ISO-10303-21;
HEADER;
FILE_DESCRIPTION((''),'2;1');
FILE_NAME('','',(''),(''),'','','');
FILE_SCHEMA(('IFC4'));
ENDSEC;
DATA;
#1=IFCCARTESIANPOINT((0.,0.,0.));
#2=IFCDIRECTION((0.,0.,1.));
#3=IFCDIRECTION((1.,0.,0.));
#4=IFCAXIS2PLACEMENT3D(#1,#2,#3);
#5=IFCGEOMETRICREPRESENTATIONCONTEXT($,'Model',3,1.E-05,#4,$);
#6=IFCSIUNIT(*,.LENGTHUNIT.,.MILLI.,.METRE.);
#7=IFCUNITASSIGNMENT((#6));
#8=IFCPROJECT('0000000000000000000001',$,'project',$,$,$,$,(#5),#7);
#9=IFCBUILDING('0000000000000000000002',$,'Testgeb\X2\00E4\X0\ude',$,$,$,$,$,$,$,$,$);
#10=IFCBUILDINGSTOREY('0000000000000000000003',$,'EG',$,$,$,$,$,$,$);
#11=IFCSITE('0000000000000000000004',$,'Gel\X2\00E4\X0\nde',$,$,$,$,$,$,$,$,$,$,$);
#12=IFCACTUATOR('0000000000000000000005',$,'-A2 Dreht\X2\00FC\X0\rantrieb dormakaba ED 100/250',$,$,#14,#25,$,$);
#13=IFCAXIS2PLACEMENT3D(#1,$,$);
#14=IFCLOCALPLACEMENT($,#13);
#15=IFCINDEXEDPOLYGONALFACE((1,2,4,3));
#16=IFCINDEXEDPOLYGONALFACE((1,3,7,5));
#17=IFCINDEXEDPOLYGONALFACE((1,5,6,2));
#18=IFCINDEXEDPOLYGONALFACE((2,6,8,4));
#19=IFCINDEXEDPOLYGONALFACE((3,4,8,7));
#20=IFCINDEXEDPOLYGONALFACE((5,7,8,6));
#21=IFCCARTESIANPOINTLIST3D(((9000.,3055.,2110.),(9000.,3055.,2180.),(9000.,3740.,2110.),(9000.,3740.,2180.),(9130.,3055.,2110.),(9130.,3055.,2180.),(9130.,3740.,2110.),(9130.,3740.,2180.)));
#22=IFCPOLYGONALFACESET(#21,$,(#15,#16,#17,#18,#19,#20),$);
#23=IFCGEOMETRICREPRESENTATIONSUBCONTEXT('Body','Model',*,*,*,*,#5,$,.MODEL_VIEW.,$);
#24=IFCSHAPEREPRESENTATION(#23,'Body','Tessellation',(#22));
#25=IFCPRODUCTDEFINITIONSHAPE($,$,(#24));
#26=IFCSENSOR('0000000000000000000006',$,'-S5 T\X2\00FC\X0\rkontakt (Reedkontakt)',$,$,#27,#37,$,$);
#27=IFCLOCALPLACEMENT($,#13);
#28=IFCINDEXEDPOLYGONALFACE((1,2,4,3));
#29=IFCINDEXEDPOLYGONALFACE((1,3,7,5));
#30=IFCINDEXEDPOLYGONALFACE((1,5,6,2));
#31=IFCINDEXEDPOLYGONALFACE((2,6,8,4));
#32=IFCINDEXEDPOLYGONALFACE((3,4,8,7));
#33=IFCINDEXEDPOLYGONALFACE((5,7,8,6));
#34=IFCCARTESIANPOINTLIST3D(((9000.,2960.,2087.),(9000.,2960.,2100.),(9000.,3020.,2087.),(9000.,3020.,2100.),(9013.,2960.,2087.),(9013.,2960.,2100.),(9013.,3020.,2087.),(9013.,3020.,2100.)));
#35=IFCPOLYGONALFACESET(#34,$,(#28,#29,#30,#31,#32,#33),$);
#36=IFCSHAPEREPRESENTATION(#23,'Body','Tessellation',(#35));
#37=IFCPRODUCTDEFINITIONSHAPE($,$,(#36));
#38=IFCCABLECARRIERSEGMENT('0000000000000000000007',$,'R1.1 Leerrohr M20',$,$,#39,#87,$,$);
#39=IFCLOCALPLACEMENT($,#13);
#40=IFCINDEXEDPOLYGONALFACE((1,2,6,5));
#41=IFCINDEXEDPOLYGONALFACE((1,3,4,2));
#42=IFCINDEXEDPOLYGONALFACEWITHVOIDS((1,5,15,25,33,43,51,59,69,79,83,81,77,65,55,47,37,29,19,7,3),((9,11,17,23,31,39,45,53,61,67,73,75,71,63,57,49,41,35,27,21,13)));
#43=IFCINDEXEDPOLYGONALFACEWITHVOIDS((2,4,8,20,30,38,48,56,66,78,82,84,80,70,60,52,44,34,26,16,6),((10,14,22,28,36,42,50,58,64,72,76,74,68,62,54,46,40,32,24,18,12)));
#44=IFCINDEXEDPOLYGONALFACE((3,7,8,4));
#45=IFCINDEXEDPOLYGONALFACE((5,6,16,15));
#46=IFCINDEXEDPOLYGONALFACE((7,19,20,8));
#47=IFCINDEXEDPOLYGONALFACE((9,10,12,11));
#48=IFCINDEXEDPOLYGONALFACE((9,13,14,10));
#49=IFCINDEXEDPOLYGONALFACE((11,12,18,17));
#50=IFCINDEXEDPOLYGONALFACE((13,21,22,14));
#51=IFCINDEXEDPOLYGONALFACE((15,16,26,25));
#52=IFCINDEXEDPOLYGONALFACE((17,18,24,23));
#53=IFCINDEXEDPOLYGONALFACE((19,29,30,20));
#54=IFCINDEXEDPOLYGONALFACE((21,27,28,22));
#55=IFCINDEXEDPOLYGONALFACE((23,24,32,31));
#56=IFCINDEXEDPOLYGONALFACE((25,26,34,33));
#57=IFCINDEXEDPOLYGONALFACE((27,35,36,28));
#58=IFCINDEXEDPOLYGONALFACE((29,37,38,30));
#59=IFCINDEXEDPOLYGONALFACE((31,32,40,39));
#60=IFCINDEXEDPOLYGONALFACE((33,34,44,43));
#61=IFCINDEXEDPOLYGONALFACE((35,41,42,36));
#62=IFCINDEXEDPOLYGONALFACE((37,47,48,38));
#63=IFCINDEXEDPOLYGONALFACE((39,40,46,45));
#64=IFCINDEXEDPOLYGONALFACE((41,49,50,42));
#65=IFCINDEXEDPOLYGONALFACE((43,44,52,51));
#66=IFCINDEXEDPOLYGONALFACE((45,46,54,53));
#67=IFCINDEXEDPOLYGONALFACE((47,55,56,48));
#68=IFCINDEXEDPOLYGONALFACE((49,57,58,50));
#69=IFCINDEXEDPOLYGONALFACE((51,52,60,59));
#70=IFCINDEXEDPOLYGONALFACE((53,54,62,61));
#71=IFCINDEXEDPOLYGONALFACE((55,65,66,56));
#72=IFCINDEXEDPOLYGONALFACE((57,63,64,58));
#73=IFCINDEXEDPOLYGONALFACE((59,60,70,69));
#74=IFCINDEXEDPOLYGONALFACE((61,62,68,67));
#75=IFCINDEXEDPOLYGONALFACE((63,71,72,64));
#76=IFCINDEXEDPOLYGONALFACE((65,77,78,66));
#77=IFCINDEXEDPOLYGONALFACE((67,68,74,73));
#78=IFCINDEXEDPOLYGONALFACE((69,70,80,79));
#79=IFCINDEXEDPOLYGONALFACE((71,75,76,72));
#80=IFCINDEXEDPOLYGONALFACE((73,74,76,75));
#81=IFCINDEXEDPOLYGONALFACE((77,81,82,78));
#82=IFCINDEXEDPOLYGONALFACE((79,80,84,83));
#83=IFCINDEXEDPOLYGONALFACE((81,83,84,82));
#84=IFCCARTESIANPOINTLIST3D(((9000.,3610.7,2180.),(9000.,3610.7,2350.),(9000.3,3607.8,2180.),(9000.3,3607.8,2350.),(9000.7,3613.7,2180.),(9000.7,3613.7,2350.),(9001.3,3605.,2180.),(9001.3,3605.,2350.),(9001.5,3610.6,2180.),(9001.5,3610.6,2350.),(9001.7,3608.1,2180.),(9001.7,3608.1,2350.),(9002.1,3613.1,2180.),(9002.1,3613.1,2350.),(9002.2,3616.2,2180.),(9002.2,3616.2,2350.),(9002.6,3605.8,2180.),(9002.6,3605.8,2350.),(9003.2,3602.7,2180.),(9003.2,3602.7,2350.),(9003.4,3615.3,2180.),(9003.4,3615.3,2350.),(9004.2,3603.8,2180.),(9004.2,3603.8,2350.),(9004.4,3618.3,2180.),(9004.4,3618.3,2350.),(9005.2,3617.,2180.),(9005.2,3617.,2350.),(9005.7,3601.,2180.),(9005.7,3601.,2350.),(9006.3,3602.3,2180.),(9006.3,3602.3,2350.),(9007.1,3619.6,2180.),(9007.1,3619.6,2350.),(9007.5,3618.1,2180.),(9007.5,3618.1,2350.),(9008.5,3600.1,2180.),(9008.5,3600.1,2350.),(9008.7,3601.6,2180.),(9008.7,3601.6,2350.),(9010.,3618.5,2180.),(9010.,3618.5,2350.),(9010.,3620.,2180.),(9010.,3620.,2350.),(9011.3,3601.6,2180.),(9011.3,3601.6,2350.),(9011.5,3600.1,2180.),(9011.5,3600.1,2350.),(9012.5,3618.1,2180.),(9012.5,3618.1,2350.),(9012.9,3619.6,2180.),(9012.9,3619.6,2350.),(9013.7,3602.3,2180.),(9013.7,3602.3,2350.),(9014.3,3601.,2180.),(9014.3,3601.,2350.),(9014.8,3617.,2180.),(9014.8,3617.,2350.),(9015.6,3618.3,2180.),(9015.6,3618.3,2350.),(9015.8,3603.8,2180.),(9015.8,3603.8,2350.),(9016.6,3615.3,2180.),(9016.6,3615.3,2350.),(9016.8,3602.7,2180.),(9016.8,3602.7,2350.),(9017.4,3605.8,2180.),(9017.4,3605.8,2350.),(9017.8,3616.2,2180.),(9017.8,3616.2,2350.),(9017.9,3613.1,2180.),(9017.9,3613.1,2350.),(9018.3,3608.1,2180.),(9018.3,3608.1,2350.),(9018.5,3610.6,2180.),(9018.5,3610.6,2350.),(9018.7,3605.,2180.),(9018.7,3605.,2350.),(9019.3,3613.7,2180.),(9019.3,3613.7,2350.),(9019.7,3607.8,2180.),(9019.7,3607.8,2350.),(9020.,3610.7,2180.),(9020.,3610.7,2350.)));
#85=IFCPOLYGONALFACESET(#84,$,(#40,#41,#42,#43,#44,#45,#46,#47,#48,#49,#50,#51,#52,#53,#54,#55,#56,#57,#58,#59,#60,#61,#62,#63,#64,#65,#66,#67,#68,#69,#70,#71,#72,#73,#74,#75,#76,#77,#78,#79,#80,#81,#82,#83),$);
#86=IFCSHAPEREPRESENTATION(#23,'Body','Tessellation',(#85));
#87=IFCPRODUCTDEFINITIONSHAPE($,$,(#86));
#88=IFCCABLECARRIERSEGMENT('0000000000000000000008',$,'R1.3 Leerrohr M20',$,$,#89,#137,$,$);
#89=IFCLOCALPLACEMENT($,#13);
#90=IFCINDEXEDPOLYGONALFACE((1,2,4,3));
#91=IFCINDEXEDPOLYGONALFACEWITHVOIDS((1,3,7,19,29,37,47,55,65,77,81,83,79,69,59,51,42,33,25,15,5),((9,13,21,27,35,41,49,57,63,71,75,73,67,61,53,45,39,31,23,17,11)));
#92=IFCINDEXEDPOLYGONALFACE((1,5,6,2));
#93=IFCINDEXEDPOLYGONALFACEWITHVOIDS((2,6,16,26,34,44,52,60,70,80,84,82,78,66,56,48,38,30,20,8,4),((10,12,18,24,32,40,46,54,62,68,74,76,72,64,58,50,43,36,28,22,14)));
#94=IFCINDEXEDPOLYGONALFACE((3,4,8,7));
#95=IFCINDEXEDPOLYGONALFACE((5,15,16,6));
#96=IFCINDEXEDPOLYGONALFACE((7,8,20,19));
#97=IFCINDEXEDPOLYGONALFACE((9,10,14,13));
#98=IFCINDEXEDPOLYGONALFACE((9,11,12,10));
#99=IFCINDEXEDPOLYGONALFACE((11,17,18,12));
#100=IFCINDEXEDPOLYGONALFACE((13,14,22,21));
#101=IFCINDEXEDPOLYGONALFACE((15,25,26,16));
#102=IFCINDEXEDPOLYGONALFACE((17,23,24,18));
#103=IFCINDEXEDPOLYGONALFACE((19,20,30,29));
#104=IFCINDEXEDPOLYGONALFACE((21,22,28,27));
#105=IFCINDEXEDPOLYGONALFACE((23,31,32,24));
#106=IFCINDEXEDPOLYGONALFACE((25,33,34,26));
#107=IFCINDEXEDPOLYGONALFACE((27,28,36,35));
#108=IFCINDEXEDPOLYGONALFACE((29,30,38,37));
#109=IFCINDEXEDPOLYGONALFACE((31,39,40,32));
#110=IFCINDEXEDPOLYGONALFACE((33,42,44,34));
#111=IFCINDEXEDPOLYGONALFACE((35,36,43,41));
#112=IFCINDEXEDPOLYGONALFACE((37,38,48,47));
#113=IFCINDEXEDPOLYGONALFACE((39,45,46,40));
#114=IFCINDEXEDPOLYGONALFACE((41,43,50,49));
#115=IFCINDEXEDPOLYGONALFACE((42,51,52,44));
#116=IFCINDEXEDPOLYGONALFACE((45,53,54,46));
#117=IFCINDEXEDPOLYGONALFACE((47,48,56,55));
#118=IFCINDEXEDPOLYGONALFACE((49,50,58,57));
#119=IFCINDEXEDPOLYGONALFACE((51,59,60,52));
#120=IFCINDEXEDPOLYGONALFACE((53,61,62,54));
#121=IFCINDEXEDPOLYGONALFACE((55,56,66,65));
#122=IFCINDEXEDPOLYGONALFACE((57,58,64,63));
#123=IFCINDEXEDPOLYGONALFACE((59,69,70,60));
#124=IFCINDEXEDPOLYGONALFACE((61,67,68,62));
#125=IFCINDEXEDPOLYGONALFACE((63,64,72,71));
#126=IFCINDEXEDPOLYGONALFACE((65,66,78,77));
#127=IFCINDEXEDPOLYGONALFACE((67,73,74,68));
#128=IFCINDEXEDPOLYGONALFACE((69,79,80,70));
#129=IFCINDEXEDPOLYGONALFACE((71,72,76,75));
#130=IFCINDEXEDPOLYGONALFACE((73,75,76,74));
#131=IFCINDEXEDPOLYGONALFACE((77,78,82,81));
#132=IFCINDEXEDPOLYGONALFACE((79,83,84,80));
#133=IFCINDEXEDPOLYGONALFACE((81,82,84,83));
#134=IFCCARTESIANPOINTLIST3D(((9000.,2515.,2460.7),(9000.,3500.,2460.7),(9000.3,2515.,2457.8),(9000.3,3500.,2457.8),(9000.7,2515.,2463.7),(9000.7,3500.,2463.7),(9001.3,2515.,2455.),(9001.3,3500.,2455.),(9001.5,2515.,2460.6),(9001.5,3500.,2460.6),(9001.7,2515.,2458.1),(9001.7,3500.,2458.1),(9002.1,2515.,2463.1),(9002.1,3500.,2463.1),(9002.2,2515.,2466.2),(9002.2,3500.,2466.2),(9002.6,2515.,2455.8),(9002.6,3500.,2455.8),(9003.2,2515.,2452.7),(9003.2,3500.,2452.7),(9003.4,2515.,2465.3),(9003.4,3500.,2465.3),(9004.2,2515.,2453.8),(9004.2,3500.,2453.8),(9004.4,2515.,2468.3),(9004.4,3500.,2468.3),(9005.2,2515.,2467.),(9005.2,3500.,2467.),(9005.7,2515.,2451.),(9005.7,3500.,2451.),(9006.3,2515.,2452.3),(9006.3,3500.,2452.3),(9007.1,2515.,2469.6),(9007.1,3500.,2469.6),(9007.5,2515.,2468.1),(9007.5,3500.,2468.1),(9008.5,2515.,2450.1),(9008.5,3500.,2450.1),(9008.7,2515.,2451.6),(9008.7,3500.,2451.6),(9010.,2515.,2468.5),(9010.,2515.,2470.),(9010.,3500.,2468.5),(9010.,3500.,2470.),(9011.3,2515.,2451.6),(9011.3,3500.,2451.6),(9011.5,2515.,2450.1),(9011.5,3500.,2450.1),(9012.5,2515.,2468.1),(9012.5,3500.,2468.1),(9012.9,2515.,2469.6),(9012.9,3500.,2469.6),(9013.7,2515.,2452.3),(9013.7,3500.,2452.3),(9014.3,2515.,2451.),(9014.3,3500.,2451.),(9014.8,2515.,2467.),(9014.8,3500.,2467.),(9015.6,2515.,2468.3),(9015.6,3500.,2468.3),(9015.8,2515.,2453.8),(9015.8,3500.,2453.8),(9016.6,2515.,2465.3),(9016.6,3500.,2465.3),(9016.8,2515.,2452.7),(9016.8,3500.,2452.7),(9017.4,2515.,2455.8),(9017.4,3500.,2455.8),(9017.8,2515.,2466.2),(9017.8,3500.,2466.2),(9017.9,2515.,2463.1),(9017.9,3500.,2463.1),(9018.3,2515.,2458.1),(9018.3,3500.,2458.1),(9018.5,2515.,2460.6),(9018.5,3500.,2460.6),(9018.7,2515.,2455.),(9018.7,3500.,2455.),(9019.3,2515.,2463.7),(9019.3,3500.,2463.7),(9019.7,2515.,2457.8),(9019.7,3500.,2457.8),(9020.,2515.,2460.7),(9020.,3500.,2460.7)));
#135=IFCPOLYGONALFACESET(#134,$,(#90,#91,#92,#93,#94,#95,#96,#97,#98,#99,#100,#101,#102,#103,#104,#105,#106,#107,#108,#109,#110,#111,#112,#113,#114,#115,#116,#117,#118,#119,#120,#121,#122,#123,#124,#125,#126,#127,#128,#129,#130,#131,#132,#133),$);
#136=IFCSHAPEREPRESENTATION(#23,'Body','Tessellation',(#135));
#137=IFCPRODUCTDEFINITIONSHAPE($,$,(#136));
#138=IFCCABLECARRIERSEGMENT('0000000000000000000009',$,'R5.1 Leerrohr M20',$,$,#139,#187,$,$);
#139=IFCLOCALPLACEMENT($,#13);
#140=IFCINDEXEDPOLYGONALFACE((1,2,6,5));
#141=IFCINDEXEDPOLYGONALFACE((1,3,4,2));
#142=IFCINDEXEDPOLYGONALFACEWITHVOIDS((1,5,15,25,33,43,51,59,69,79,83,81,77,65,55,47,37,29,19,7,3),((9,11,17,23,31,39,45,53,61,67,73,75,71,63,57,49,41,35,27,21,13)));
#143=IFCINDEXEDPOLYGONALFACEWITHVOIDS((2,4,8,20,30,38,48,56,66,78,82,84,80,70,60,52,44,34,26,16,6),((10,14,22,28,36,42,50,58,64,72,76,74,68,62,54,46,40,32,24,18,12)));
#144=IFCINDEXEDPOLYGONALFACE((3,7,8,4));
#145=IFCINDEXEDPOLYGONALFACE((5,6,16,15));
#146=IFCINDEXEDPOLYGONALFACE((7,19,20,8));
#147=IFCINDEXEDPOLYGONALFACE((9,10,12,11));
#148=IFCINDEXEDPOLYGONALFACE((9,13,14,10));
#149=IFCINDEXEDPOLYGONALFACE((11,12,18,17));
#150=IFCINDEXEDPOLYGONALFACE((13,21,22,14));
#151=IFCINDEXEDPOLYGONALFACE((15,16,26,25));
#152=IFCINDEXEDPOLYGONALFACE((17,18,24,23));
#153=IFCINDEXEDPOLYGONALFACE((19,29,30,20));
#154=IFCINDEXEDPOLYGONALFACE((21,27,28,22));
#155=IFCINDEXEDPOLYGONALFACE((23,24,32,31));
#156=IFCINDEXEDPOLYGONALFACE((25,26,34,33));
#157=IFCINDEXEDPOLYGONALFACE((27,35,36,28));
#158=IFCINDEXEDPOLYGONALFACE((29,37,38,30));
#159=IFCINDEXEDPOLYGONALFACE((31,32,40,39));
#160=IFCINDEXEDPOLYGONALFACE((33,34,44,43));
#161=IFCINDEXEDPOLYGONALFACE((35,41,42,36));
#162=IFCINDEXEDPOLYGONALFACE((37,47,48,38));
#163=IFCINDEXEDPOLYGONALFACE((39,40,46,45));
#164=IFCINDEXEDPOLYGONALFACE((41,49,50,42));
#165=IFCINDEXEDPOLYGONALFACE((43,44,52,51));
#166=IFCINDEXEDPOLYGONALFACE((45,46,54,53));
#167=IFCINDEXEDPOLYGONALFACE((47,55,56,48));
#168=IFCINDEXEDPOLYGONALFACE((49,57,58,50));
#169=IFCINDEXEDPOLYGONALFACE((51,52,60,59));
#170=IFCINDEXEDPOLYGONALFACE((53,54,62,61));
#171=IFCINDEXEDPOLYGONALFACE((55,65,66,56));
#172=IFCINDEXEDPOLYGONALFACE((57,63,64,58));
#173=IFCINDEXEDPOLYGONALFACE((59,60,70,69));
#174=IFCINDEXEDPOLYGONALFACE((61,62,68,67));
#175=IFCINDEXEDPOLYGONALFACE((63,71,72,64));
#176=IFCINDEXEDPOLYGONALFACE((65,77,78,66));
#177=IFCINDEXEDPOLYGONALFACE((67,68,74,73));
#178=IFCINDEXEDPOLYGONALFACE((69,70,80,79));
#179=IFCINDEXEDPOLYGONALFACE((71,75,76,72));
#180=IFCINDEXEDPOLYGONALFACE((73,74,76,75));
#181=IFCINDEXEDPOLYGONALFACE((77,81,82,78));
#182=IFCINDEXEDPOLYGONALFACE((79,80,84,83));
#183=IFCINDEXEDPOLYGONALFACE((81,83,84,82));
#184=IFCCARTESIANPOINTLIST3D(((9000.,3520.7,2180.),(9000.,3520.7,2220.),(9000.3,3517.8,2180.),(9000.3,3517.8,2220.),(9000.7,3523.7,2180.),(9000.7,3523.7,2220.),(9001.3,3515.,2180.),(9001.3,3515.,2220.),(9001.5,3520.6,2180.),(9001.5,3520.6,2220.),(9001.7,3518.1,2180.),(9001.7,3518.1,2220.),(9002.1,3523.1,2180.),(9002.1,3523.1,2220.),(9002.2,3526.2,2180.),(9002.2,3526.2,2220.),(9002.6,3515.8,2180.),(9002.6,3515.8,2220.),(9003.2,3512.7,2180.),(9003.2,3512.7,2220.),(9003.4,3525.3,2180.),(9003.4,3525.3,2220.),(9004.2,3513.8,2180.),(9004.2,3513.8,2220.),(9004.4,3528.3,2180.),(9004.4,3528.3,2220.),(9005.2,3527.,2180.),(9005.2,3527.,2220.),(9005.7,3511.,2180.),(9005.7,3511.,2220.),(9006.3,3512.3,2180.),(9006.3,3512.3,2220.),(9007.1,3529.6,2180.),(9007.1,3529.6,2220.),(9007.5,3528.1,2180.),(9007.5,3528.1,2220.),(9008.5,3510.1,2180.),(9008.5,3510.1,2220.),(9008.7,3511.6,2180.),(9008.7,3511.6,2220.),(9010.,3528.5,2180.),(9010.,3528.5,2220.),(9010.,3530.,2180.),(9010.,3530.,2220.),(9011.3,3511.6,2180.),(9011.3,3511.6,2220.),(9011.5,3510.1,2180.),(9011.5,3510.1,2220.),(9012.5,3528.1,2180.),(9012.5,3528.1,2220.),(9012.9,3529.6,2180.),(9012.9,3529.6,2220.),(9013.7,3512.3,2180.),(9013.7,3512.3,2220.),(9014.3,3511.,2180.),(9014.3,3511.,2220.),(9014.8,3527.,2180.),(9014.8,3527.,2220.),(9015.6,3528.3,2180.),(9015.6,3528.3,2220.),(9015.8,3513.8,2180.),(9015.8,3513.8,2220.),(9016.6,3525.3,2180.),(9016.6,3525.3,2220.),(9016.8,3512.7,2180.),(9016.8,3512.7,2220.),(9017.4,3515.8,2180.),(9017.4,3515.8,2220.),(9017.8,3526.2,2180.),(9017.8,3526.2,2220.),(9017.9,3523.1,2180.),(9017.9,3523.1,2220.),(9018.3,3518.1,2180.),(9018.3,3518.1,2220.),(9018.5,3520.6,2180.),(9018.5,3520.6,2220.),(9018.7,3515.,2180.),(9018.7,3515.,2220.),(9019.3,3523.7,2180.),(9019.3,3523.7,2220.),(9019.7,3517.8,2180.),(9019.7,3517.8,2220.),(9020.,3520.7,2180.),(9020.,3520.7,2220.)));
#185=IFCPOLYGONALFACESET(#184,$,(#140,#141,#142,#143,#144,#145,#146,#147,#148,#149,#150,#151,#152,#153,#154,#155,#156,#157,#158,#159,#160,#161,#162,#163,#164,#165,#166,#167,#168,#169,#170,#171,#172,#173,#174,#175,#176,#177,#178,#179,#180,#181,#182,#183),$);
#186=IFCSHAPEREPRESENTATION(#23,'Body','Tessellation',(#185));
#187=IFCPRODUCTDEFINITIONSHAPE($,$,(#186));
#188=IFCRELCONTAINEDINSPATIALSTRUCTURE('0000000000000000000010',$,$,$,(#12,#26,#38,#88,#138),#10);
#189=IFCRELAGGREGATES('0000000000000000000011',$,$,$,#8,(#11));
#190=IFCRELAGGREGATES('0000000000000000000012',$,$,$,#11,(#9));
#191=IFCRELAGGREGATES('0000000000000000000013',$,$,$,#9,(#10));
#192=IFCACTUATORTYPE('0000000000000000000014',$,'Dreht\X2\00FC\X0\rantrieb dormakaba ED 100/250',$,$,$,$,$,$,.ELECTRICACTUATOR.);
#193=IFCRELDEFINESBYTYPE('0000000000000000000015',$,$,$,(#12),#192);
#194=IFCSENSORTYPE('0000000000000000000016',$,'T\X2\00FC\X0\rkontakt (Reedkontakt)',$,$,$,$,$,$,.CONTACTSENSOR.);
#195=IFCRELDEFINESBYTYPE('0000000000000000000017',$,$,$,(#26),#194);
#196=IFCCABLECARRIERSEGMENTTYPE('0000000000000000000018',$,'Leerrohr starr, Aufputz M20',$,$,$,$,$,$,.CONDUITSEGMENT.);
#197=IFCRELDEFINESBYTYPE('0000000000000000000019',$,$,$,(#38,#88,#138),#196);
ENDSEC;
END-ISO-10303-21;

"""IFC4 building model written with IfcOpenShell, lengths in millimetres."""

from ifc_helpers import new_model, si_unit, frame, frame_2d, origin_with_axes, place, context, subcontext, project, spatial, rectangle, hollow_circle, extrude, type_object, element, save


model = new_model("IFC4")

# Units and contexts
model_context = context("Model", 3, precision=1e-05, world=origin_with_axes())
body_context = subcontext(model_context, "Body", "Model", "MODEL_VIEW")
ifc_project = project(units=[si_unit("LENGTHUNIT", "METRE", prefix="MILLI")], contexts=[model_context])

# Site, building, storey
site = spatial("IfcSite", under=ifc_project, Name="Gelände")
building = spatial("IfcBuilding", under=site, Name="Testgebäude")
storey = spatial("IfcBuildingStorey", under=building, Name="EG")

# Actuator
actuator_type = type_object("IfcActuatorType", Name="Drehtürantrieb dormakaba ED 100/250", PredefinedType="ELECTRICACTUATOR")
actuator_placement = place(None, frame((9130.0, 3055.0, 2110.0), z_axis=(0.0, 0.0, 1.0), x_axis=(0.0, 1.0, 0.0)))
element("IfcActuator", 1, at=actuator_placement, inside=storey, type_object=actuator_type, Name="-A2 Drehtürantrieb dormakaba ED 100/250", context=body_context, shape_type="SweptSolid", body=[
    extrude(rectangle(XDim=685.0, YDim=130.0, at=frame_2d((342.5, 65.0))), None, (0.0, 0.0, 1.0), 70.0),
])

# Sensor
sensor_type = type_object("IfcSensorType", Name="Türkontakt (Reedkontakt)", PredefinedType="CONTACTSENSOR")
sensor_placement = place(None, frame((9013.0, 2960.0, 2087.0), z_axis=(0.0, 0.0, 1.0), x_axis=(0.0, 1.0, 0.0)))
element("IfcSensor", 2, at=sensor_placement, inside=storey, type_object=sensor_type, Name="-S5 Türkontakt (Reedkontakt)", context=body_context, shape_type="SweptSolid", body=[
    extrude(rectangle(XDim=60.0, YDim=13.0, at=frame_2d((30.0, 6.5))), None, (0.0, 0.0, 1.0), 13.0),
])

# Cable carrier segments
cable_carrier_segment_type_1 = type_object("IfcCableCarrierSegmentType", Name="Leerrohr starr, Aufputz M20", PredefinedType="CONDUITSEGMENT")
cable_carrier_segment_1_placement = place(None, frame((9010.0, 3610.0, 2180.0), z_axis=(0.0, 0.0, 1.0), x_axis=(0.0, 1.0, 0.0)))
element("IfcCableCarrierSegment", 3, at=cable_carrier_segment_1_placement, inside=storey, type_object=cable_carrier_segment_type_1, Name="R1.1 Leerrohr M20", context=body_context, shape_type="SweptSolid", body=[
    extrude(hollow_circle(Radius=10.0, WallThickness=1.5), None, (0.0, 0.0, 1.0), 170.0),
])
cable_carrier_segment_2_placement = place(None, frame((9010.0, 3500.0, 2460.0), z_axis=(0.0, -1.0, 0.0), x_axis=(0.0, 0.0, 1.0)))
element("IfcCableCarrierSegment", 4, at=cable_carrier_segment_2_placement, inside=storey, type_object=cable_carrier_segment_type_1, Name="R1.3 Leerrohr M20", context=body_context, shape_type="SweptSolid", body=[
    extrude(hollow_circle(Radius=10.0, WallThickness=1.5), None, (0.0, 0.0, 1.0), 985.0),
])
cable_carrier_segment_3_placement = place(None, frame((9010.0, 3520.0, 2180.0), z_axis=(0.0, 0.0, 1.0), x_axis=(0.0, 1.0, 0.0)))
element("IfcCableCarrierSegment", 5, at=cable_carrier_segment_3_placement, inside=storey, type_object=cable_carrier_segment_type_1, Name="R5.1 Leerrohr M20", context=body_context, shape_type="SweptSolid", body=[
    extrude(hollow_circle(Radius=10.0, WallThickness=1.5), None, (0.0, 0.0, 1.0), 40.0),
])

save(model, "model.ifc")
